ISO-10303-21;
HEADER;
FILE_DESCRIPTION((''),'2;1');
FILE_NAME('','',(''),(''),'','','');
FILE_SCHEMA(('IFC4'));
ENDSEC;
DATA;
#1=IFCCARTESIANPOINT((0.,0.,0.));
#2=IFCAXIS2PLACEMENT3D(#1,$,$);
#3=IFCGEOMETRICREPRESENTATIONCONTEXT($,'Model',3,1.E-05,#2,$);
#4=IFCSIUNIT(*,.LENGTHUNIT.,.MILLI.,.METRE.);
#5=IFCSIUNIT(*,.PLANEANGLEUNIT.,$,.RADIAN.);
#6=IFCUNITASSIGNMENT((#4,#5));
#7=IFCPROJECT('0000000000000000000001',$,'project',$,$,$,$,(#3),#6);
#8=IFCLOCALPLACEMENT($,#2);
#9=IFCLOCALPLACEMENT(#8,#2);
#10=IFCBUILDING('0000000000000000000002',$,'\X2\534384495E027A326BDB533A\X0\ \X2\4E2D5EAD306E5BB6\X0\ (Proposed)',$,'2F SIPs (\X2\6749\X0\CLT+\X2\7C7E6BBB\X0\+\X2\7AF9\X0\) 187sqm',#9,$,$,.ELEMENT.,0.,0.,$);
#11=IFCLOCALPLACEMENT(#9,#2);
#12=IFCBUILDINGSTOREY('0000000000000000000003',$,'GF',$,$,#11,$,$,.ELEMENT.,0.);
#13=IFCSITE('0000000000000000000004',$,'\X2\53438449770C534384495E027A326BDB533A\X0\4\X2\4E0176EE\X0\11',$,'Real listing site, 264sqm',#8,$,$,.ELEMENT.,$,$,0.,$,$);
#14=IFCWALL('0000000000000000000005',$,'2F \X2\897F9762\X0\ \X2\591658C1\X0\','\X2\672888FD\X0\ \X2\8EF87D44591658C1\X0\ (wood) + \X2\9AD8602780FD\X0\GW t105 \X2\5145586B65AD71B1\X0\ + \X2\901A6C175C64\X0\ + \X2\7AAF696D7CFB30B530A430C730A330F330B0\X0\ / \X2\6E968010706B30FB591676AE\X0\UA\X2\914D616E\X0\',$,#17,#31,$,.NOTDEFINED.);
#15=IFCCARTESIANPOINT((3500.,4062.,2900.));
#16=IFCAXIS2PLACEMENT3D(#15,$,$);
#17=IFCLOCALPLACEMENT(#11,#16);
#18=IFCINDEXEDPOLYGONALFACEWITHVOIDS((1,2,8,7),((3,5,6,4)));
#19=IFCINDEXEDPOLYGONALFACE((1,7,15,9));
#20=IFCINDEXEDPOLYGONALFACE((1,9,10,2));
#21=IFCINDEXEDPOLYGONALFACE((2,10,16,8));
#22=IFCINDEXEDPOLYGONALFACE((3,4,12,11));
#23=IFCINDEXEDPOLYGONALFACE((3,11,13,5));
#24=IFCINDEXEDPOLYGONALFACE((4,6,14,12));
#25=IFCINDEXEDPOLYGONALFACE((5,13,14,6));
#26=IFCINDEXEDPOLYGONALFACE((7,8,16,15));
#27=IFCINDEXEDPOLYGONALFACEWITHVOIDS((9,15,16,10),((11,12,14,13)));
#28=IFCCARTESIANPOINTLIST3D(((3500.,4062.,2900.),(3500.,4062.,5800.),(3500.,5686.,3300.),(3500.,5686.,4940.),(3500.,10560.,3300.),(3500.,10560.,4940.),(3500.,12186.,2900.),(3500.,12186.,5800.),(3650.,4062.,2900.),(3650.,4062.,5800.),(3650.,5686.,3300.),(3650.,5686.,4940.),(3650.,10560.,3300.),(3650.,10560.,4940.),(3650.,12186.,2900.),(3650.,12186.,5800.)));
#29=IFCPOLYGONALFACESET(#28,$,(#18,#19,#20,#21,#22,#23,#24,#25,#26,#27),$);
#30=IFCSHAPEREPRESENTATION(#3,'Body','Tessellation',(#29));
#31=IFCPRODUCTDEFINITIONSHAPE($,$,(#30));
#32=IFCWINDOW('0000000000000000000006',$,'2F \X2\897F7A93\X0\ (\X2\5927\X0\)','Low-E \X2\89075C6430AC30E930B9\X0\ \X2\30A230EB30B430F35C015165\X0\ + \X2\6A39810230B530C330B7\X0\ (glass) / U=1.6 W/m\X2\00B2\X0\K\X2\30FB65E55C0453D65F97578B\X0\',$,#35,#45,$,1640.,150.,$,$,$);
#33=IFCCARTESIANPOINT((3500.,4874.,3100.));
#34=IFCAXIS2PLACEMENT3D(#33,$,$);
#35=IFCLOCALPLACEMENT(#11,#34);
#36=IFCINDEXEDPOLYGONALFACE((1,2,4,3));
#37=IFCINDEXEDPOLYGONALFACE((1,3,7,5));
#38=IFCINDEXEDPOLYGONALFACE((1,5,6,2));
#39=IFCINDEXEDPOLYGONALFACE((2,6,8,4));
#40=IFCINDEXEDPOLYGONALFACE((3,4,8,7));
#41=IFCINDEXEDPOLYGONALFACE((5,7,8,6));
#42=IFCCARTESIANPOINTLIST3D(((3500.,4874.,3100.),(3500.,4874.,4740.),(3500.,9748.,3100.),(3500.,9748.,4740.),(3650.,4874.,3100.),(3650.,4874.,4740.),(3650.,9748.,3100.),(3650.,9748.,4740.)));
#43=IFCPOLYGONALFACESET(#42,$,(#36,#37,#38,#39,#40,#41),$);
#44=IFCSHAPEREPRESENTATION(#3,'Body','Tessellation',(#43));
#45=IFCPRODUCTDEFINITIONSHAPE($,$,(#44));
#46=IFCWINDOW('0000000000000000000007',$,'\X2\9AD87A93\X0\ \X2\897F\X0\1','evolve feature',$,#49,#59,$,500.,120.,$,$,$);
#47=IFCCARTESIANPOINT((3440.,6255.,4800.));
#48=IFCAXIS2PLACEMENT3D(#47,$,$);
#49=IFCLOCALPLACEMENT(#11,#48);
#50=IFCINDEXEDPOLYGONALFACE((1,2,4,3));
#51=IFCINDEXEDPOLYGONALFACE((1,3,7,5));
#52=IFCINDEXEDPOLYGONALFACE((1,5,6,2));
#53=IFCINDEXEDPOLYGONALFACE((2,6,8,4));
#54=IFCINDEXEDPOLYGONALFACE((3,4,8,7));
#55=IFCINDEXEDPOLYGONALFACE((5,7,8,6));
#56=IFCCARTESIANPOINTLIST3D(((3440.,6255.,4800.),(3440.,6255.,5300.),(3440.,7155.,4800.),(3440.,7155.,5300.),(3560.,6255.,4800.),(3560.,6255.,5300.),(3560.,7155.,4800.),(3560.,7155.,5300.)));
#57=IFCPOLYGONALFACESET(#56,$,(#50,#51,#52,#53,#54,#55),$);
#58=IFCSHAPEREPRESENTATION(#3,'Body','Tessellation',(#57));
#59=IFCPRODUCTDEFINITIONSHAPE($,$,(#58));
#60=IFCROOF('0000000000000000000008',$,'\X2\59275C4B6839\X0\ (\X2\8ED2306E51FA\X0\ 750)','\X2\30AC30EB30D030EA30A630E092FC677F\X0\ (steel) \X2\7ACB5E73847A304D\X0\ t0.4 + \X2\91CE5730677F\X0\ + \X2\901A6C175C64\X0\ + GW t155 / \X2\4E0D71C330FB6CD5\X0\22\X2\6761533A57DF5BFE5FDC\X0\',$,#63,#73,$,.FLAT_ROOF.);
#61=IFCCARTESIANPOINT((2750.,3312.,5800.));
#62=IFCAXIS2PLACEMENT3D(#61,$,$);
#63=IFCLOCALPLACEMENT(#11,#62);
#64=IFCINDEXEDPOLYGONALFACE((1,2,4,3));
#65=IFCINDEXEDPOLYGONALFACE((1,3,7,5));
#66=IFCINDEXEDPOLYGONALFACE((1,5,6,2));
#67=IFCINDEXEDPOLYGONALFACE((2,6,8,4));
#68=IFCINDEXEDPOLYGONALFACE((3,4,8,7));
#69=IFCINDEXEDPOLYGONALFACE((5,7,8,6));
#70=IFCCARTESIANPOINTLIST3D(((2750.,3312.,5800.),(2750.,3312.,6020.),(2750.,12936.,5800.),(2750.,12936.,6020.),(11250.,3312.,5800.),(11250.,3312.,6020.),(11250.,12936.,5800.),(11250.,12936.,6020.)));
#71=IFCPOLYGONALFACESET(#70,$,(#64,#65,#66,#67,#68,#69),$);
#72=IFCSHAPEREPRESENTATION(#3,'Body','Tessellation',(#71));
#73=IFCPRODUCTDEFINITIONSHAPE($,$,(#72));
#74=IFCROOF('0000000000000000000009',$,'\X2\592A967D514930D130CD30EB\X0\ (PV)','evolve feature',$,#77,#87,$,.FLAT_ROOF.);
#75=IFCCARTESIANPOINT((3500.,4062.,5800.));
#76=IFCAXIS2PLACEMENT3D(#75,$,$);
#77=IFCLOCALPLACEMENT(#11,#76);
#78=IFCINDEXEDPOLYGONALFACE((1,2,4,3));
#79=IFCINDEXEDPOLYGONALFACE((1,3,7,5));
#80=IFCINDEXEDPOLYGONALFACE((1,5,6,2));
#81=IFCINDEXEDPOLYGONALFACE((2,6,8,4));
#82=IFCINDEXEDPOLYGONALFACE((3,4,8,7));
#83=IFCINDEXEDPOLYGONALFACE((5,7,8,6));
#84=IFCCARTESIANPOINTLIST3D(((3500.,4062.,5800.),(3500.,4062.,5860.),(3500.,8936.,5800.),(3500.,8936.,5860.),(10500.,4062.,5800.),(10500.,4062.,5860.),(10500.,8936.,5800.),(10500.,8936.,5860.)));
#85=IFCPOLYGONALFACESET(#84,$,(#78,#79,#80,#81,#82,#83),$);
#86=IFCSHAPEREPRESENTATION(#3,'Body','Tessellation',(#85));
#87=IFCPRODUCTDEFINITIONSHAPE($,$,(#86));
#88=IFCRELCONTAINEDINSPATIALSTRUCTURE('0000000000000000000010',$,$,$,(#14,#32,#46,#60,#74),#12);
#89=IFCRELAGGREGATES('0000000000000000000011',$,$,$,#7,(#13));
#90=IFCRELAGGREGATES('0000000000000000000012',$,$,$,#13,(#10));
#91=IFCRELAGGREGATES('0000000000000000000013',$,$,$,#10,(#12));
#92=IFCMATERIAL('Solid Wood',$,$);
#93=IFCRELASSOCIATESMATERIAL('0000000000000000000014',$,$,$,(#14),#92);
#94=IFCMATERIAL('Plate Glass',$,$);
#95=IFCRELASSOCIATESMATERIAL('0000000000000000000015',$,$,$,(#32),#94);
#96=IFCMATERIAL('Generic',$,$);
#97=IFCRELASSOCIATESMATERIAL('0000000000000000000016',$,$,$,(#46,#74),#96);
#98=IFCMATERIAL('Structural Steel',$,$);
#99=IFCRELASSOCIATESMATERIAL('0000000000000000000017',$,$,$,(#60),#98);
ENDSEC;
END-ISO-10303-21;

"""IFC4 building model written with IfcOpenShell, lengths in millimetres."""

from ifc_helpers import new_model, si_unit, frame, frame_2d, origin, place, context, project, spatial, rectangle, extrude, material, element, fill, save


model = new_model("IFC4")

# Units and contexts
model_context = context("Model", 3, precision=1e-05, world=origin())
ifc_project = project(units=[si_unit("LENGTHUNIT", "METRE", prefix="MILLI"), si_unit("PLANEANGLEUNIT", "RADIAN")], contexts=[model_context])

# Site, building, storey
site_placement = place(None, origin())
site = spatial("IfcSite", under=ifc_project, at=site_placement, Name="千葉県千葉市稲毛区4丁目11", ObjectType="Real listing site, 264sqm", CompositionType="ELEMENT", RefElevation=0.0)
building_placement = place(site_placement, origin())
building = spatial("IfcBuilding", under=site, at=building_placement, Name="千葉市稲毛区 中庭の家 (Proposed)", ObjectType="2F SIPs (杉CLT+籾殻+竹) 187sqm", CompositionType="ELEMENT", ElevationOfRefHeight=0.0, ElevationOfTerrain=0.0)
storey_placement = place(building_placement, origin())
storey = spatial("IfcBuildingStorey", under=building, at=storey_placement, Name="GF", CompositionType="ELEMENT", Elevation=0.0)

# Shared definitions
ifc_material_1 = material(Name="Solid Wood")
ifc_material_2 = material(Name="Generic")

# Shared definitions
ifc_material_3 = material(Name="Plate Glass")

# Wall, openings, windows
wall_1_placement = place(storey_placement, frame((3500.0, 4062.0, 2900.0)))
wall_1 = element("IfcWall", 1, at=wall_1_placement, inside=storey, material=ifc_material_1, Name="2F 西面 外壁", Description="木製 軸組外壁 (wood) + 高性能GW t105 充填断熱 + 通気層 + 窯業系サイディング / 準耐火・外皮UA配慮", PredefinedType="NOTDEFINED", context=model_context, shape_type="SweptSolid", body=[
    extrude(rectangle(XDim=150.0, YDim=8124.0, at=frame_2d((75.0, 4062.0))), frame((3500.0, 4062.0, 2900.0)), (0.0, 0.0, 1.0), 2900.0),
])
opening_1_placement = place(storey_placement, frame((3500.0, 4874.0, 3100.0)))
opening_1 = element("IfcOpeningElement", 2, at=opening_1_placement, cuts=wall_1, PredefinedType="NOTDEFINED", context=model_context, shape_type="SweptSolid", body=[
    extrude(rectangle(XDim=150.0, YDim=4874.0, at=frame_2d((75.0, 2437.0))), frame((3500.0, 4874.0, 3100.0)), (0.0, 0.0, 1.0), 1640.0),
])
opening_2_placement = place(storey_placement, frame((3440.0, 6255.0, 4800.0)))
opening_2 = element("IfcOpeningElement", 3, at=opening_2_placement, cuts=wall_1, PredefinedType="NOTDEFINED", context=model_context, shape_type="SweptSolid", body=[
    extrude(rectangle(XDim=120.0, YDim=900.0, at=frame_2d((60.0, 450.0))), frame((3440.0, 6255.0, 4800.0)), (0.0, 0.0, 1.0), 500.0),
])
window_1_placement = place(storey_placement, frame((3500.0, 4874.0, 3100.0)))
window_1 = element("IfcWindow", 4, at=window_1_placement, inside=storey, material=ifc_material_3, Name="2F 西窓 (大)", Description="Low-E 複層ガラス アルゴン封入 + 樹脂サッシ (glass) / U=1.6 W/m²K・日射取得型", OverallHeight=1640.0, OverallWidth=150.0, context=model_context, shape_type="SweptSolid", body=[
    extrude(rectangle(XDim=150.0, YDim=4874.0, at=frame_2d((75.0, 2437.0))), frame((3500.0, 4874.0, 3100.0)), (0.0, 0.0, 1.0), 1640.0),
])
fill(opening_1, window_1)
window_2_placement = place(storey_placement, frame((3440.0, 6255.0, 4800.0)))
window_2 = element("IfcWindow", 5, at=window_2_placement, inside=storey, material=ifc_material_2, Name="高窓 西1", Description="evolve feature", OverallHeight=500.0, OverallWidth=120.0, context=model_context, shape_type="SweptSolid", body=[
    extrude(rectangle(XDim=120.0, YDim=900.0, at=frame_2d((60.0, 450.0))), frame((3440.0, 6255.0, 4800.0)), (0.0, 0.0, 1.0), 500.0),
])
fill(opening_2, window_2)

# Roofs
ifc_material_4 = material(Name="Structural Steel")
roof_1_placement = place(storey_placement, frame((2750.0, 3312.0, 5800.0)))
element("IfcRoof", 6, at=roof_1_placement, inside=storey, material=ifc_material_4, Name="大屋根 (軒の出 750)", Description="ガルバリウム鋼板 (steel) 立平葺き t0.4 + 野地板 + 通気層 + GW t155 / 不燃・法22条区域対応", PredefinedType="FLAT_ROOF", context=model_context, shape_type="SweptSolid", body=[
    extrude(rectangle(XDim=8500.0, YDim=9624.0, at=frame_2d((4250.0, 4812.0))), frame((2750.0, 3312.0, 5800.0)), (0.0, 0.0, 1.0), 220.0),
])
roof_2_placement = place(storey_placement, frame((3500.0, 4062.0, 5800.0)))
element("IfcRoof", 7, at=roof_2_placement, inside=storey, material=ifc_material_2, Name="太陽光パネル (PV)", Description="evolve feature", PredefinedType="FLAT_ROOF", context=model_context, shape_type="SweptSolid", body=[
    extrude(rectangle(XDim=7000.0, YDim=4874.0, at=frame_2d((3500.0, 2437.0))), frame((3500.0, 4062.0, 5800.0)), (0.0, 0.0, 1.0), 60.0),
])

save(model, "model.ifc")
